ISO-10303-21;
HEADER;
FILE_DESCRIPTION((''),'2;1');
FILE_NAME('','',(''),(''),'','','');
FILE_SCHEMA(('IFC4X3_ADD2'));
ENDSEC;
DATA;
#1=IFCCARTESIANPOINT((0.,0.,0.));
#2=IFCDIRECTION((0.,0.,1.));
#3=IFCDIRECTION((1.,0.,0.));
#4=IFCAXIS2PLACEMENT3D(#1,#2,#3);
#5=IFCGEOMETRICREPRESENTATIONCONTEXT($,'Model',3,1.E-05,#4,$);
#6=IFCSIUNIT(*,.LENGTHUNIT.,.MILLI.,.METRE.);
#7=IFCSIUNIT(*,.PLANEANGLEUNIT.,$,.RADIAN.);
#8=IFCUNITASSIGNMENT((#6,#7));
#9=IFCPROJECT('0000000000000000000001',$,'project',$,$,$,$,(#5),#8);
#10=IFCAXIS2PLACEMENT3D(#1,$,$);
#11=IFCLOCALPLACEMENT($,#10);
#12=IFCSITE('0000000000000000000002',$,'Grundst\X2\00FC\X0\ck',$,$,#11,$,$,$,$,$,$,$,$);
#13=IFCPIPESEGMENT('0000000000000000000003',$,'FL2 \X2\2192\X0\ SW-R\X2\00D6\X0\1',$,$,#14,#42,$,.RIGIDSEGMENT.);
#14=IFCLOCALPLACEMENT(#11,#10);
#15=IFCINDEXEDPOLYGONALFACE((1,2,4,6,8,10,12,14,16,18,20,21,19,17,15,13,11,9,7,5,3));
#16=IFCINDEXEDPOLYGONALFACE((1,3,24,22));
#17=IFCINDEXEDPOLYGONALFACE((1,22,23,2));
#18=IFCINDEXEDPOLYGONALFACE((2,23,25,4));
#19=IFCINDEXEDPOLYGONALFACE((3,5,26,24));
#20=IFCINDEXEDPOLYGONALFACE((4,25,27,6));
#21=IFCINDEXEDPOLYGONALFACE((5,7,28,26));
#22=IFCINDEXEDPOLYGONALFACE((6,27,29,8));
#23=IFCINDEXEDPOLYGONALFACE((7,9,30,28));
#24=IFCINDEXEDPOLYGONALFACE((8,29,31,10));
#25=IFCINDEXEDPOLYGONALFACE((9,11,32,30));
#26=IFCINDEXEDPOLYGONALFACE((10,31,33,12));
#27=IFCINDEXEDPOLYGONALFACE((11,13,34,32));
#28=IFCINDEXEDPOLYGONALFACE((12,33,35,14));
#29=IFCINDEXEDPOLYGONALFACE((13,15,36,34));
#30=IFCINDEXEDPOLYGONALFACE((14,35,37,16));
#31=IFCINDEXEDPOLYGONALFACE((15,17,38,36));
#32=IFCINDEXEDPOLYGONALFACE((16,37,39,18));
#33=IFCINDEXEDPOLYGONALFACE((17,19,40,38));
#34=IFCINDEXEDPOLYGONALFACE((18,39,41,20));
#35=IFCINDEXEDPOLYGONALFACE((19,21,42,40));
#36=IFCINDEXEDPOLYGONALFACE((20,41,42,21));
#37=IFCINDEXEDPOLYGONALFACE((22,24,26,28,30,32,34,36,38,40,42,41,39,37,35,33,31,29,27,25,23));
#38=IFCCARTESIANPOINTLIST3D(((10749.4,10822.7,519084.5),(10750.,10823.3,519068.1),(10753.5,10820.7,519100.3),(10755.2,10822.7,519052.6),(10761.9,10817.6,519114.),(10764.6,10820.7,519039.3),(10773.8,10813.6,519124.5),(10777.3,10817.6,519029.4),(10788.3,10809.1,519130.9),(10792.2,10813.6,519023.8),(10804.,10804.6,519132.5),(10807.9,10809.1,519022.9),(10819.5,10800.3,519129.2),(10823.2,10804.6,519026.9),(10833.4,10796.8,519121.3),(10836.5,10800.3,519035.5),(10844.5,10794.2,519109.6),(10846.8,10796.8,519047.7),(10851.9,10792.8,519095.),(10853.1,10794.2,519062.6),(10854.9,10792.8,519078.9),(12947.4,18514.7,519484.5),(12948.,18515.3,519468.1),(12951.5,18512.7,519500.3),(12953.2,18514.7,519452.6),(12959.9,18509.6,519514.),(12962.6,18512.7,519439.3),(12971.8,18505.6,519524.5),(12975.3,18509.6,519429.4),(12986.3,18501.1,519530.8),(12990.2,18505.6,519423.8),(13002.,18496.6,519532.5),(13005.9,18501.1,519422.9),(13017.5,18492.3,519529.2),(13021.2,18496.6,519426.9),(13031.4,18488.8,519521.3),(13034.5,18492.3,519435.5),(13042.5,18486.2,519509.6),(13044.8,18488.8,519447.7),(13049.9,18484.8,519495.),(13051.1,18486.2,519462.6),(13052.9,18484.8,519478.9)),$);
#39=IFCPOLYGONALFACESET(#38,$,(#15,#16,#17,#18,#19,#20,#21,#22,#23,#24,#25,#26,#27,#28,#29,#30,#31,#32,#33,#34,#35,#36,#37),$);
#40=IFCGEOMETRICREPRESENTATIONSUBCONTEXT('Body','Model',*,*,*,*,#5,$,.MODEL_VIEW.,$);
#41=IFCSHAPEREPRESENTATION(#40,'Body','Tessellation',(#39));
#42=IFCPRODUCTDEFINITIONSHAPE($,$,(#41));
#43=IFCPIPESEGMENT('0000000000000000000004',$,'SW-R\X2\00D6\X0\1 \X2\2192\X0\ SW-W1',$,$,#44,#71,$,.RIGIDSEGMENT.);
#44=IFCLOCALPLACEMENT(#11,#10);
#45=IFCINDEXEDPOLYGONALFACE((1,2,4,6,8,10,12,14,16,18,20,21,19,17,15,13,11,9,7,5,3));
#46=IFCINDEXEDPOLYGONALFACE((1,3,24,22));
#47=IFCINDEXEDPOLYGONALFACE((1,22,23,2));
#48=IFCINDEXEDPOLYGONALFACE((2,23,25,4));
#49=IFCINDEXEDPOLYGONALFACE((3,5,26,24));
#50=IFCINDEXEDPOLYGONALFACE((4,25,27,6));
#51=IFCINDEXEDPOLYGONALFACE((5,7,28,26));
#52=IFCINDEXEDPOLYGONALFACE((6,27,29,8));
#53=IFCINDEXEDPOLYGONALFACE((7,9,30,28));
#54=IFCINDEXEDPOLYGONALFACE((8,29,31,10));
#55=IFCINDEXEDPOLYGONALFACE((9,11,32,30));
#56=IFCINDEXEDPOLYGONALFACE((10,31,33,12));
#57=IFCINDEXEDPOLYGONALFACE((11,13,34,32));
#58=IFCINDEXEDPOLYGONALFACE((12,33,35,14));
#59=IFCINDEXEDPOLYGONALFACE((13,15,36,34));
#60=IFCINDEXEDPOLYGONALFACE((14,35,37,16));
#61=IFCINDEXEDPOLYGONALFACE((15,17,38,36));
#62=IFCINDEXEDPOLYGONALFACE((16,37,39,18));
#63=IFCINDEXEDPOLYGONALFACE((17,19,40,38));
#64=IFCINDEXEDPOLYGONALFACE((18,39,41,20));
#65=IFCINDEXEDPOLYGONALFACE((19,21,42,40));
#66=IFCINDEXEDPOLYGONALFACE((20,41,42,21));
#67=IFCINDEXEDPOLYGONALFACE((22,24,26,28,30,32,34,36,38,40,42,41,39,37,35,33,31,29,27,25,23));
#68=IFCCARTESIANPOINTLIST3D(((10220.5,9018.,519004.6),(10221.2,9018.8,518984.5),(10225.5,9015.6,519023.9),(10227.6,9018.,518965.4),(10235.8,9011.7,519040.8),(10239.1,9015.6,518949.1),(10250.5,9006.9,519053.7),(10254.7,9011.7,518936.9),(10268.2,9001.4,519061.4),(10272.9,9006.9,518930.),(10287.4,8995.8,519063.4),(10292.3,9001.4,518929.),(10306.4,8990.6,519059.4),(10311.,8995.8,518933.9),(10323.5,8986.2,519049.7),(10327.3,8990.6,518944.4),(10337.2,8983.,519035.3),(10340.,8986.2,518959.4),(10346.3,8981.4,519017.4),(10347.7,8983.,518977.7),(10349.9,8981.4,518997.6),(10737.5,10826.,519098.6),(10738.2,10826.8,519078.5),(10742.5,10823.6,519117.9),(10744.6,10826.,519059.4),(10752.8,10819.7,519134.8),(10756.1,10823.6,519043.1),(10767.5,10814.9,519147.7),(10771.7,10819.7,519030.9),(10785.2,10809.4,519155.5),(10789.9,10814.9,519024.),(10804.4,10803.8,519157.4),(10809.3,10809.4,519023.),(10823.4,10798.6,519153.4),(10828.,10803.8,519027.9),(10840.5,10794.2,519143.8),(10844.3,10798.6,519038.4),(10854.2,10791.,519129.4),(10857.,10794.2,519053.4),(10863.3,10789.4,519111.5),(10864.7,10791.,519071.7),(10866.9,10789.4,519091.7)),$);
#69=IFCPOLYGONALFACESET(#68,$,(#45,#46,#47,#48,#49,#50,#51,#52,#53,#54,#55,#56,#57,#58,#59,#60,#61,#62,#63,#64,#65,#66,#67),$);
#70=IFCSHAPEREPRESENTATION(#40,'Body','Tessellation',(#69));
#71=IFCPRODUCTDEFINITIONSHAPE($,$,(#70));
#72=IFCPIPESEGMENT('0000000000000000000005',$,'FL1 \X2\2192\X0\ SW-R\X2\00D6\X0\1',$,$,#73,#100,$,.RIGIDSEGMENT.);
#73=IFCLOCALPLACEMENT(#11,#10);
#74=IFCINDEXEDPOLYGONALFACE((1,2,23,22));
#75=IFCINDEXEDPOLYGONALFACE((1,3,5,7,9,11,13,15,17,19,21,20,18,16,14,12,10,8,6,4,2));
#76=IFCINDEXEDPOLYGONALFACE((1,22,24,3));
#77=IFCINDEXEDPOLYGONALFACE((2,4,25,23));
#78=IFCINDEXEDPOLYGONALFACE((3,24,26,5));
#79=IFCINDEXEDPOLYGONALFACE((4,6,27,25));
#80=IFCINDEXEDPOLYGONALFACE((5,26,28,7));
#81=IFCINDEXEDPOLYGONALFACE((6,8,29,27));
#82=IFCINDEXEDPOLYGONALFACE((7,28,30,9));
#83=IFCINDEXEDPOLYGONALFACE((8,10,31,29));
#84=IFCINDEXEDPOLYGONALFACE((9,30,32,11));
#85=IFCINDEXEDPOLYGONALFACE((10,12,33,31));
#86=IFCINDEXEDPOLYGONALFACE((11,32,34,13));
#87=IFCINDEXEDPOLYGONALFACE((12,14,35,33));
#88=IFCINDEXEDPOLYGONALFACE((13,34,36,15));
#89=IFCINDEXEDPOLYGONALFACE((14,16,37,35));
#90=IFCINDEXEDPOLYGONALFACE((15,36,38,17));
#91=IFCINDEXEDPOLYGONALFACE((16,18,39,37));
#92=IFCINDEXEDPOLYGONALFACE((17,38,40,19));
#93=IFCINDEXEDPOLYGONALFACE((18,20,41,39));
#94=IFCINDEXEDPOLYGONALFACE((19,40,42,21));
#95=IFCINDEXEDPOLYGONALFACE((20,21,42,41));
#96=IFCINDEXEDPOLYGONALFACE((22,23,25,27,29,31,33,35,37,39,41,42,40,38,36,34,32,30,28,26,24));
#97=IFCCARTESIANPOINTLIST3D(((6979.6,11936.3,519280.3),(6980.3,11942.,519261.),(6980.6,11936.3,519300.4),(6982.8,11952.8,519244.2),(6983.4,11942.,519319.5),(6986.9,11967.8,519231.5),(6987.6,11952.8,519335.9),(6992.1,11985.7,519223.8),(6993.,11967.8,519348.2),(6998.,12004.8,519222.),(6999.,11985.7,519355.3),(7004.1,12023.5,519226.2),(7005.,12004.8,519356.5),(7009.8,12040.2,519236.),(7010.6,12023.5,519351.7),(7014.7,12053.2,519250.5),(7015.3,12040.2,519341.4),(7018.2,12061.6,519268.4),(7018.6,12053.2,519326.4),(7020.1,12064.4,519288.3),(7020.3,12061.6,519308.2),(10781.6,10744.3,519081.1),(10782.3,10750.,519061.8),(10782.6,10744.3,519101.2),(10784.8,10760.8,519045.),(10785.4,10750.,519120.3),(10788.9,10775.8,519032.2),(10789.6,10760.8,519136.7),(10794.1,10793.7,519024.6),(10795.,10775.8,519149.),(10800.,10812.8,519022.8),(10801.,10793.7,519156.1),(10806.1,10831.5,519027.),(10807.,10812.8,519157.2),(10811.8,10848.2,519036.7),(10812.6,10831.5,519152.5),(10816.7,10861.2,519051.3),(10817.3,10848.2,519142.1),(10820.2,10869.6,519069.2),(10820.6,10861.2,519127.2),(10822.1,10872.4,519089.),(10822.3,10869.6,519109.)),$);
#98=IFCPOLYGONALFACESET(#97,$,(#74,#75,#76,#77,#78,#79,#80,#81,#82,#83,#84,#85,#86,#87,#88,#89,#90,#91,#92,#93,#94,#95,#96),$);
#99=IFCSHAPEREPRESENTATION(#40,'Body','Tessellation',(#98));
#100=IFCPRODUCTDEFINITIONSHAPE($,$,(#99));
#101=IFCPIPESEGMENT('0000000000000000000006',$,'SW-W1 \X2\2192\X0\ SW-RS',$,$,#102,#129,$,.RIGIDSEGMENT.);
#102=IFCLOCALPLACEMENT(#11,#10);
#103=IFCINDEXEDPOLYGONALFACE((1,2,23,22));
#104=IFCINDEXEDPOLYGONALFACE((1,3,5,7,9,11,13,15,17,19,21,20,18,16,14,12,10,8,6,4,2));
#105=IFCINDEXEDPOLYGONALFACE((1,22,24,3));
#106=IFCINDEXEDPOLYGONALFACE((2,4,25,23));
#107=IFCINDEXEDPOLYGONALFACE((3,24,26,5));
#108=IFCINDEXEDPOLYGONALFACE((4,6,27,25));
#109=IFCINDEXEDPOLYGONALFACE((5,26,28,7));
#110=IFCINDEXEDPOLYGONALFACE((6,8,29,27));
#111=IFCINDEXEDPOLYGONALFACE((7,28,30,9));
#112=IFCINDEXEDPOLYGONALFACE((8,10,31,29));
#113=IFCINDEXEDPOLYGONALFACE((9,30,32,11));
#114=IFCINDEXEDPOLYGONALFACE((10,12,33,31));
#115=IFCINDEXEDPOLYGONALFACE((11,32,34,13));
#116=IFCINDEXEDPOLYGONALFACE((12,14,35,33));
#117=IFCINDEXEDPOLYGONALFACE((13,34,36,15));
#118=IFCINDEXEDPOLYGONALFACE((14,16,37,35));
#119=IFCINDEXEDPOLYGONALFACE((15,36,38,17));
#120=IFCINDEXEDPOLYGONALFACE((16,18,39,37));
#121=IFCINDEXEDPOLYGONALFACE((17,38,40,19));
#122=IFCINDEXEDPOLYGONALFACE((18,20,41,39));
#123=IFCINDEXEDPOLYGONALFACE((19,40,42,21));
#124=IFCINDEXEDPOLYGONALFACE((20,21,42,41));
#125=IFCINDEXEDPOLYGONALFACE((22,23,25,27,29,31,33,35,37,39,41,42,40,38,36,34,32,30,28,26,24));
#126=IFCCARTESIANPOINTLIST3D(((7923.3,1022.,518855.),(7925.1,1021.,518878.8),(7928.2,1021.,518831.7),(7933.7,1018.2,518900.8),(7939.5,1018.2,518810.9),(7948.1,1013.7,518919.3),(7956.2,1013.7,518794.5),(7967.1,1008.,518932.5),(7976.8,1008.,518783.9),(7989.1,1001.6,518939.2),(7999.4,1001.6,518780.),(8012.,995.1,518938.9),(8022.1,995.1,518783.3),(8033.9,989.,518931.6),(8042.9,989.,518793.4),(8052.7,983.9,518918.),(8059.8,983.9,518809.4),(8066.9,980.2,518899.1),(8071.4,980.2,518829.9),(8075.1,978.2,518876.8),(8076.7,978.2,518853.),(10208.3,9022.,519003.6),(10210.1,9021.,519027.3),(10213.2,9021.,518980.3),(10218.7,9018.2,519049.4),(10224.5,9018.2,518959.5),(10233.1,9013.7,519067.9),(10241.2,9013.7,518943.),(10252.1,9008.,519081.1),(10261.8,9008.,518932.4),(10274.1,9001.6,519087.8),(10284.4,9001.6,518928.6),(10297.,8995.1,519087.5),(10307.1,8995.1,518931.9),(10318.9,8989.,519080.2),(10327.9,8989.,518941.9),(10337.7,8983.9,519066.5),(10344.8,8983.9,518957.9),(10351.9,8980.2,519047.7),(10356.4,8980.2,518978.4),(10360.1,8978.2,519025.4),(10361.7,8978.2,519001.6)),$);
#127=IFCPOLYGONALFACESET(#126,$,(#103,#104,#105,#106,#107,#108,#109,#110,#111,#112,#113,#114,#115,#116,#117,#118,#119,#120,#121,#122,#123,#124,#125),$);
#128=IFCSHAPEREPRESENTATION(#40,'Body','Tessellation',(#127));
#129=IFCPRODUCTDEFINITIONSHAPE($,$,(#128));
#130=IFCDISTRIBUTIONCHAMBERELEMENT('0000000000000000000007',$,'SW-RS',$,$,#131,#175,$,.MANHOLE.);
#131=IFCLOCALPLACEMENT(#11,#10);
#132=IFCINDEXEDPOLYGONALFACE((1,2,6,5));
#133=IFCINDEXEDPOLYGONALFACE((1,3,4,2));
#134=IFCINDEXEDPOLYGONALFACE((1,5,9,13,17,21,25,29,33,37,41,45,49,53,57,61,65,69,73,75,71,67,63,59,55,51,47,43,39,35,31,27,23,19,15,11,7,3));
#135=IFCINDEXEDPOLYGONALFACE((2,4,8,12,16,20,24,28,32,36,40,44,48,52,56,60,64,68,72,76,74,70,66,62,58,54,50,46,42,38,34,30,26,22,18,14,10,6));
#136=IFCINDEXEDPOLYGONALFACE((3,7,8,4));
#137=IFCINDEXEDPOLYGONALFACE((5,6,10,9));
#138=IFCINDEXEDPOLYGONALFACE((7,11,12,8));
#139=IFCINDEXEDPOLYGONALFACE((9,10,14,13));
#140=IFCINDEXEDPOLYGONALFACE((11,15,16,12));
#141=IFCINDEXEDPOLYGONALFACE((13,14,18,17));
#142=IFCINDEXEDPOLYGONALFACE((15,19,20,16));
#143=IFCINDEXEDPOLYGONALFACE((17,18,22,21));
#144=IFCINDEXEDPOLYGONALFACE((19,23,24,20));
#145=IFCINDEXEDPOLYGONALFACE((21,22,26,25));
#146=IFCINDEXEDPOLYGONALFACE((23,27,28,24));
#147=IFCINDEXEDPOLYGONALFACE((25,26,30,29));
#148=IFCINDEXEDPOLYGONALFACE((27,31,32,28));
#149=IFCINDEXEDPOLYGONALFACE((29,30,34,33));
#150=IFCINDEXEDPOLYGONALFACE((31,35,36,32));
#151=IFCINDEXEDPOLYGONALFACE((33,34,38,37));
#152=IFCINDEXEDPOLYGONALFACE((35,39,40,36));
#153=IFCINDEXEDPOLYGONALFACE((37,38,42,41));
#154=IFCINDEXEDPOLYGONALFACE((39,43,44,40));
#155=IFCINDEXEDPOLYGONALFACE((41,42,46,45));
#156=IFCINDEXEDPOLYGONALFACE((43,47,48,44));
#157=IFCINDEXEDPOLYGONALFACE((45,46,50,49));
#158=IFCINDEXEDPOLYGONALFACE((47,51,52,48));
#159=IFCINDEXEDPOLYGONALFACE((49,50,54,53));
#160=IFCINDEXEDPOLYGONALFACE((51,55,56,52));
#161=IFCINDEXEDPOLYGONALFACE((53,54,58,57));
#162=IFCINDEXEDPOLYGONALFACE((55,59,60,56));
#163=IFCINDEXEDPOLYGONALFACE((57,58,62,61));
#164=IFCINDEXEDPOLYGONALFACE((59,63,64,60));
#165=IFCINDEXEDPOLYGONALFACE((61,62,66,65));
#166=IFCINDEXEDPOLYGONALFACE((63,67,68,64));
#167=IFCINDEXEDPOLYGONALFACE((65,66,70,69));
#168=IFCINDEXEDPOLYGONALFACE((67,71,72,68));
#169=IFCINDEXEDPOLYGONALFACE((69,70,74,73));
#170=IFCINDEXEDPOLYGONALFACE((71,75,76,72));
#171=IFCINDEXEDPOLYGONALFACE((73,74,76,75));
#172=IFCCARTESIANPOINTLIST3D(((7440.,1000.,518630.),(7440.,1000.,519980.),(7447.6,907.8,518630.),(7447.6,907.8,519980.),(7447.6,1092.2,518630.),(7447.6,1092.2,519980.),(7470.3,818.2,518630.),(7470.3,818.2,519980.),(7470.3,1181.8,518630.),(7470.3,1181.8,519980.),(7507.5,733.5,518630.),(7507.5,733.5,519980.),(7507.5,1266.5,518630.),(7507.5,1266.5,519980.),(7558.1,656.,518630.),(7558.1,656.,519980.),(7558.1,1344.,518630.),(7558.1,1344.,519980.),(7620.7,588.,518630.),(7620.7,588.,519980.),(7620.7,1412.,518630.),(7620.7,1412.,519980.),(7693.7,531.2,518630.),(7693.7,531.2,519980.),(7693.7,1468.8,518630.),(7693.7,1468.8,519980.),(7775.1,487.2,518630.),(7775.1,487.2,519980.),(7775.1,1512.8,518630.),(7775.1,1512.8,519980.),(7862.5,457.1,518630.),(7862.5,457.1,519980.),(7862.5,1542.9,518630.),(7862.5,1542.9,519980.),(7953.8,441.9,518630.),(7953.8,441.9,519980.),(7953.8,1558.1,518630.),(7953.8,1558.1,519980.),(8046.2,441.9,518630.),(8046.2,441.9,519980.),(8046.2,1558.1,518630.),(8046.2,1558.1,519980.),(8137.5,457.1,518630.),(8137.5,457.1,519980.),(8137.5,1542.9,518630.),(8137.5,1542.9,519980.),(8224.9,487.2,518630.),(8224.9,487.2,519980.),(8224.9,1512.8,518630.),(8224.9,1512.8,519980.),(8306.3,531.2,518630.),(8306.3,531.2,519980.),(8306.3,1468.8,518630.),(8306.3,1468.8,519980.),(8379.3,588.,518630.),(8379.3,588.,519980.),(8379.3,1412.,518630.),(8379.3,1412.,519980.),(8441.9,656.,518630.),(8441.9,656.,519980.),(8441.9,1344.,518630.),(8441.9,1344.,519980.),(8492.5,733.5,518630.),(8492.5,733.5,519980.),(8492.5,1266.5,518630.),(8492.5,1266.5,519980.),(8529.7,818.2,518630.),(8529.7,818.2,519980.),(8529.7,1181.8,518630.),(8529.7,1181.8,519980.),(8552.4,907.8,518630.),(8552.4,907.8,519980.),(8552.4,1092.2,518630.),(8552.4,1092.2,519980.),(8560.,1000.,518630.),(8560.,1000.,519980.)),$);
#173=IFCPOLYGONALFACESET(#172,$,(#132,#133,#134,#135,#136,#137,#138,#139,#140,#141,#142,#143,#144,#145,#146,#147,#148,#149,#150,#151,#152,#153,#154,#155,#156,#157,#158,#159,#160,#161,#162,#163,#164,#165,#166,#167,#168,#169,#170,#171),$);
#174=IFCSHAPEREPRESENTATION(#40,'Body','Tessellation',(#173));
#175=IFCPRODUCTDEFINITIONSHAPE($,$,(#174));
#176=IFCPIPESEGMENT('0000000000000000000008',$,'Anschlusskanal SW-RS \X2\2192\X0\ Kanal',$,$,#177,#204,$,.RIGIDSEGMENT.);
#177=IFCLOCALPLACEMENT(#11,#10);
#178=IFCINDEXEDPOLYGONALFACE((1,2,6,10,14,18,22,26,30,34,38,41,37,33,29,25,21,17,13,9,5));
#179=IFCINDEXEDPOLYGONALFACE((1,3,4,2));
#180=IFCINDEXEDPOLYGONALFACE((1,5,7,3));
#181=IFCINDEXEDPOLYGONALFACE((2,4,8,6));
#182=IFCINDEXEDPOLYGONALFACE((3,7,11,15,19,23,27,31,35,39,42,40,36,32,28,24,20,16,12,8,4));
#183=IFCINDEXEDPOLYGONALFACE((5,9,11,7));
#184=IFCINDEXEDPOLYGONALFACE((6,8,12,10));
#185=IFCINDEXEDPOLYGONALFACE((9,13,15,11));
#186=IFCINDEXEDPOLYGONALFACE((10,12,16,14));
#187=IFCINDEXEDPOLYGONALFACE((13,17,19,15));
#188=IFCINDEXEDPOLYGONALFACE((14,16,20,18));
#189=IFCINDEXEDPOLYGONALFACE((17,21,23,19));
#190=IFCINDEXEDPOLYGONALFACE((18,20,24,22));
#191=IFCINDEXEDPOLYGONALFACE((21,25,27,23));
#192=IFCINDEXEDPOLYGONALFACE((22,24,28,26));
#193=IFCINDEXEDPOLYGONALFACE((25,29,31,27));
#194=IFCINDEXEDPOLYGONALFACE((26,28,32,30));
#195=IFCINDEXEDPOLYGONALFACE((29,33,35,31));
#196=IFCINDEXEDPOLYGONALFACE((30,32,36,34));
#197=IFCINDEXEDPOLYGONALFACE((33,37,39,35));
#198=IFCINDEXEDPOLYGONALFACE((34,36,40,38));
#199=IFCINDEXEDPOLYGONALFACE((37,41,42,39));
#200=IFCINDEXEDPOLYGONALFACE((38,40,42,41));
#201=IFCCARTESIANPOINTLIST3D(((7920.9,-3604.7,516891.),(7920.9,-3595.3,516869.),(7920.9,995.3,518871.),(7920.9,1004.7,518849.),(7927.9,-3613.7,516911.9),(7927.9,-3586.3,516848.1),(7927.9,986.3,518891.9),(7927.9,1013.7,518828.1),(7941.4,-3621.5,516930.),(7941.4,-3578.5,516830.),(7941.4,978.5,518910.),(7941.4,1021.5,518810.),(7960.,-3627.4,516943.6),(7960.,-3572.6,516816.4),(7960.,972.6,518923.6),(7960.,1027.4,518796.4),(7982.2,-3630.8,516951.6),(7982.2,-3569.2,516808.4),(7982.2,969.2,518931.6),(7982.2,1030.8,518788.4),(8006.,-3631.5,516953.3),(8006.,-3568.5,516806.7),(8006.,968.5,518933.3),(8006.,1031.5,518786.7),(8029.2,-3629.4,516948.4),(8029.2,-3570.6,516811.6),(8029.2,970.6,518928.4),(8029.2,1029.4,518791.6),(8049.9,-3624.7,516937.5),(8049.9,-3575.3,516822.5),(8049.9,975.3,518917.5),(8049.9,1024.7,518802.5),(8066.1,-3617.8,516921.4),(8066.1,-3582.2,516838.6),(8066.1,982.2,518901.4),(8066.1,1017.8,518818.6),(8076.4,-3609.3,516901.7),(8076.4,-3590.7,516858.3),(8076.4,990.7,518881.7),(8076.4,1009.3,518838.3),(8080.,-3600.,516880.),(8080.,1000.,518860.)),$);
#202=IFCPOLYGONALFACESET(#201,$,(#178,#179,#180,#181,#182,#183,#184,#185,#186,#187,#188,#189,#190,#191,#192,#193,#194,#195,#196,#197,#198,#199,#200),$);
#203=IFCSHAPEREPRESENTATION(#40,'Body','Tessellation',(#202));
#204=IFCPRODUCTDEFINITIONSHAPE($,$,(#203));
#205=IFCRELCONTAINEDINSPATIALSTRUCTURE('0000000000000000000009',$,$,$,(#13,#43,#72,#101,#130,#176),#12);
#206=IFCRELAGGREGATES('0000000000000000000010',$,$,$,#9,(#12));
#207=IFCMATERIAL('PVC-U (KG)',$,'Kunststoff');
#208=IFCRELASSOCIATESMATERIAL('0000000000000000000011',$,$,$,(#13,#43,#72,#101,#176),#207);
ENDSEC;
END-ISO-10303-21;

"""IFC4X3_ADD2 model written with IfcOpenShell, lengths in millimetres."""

from ifc_helpers import new_model, si_unit, frame, origin, origin_with_axes, place, context, subcontext, project, spatial, circle, extrude, material, element, save


model = new_model("IFC4X3_ADD2")

# Units and contexts
model_context = context("Model", 3, precision=1e-05, world=origin_with_axes())
body_context = subcontext(model_context, "Body", "Model", "MODEL_VIEW")
ifc_project = project(units=[si_unit("LENGTHUNIT", "METRE", prefix="MILLI"), si_unit("PLANEANGLEUNIT", "RADIAN")], contexts=[model_context])

# Site
site_placement = place(None, origin())
site = spatial("IfcSite", under=ifc_project, at=site_placement, Name="Grundstück")

# Pipe segments
ifc_material = material(Name="PVC-U (KG)", Category="Kunststoff")
pipe_segment_1_placement = place(site_placement, frame((13000.0, 18500.0, 519422.6)))
element("IfcPipeSegment", 1, at=pipe_segment_1_placement, inside=site, material=ifc_material, Name="FL2 → SW-RÖ1", PredefinedType="RIGIDSEGMENT", context=body_context, shape_type="SweptSolid", body=[
    extrude(circle(Radius=55.0), frame((0.0, 0.0, 55.0), z_axis=(-0.274411, -0.960315, -0.049938), x_axis=(0.0, 1.0, 0.0)), (0.0, 0.0, 1.0), 8009.9),
])
pipe_segment_2_placement = place(site_placement, frame((10802.0, 10808.0, 519022.6)))
element("IfcPipeSegment", 2, at=pipe_segment_2_placement, inside=site, material=ifc_material, Name="SW-RÖ1 → SW-W1", PredefinedType="RIGIDSEGMENT", context=body_context, shape_type="SweptSolid", body=[
    extrude(circle(Radius=67.5), frame((0.0, 0.0, 67.5), z_axis=(-0.274589, -0.960264, -0.049938), x_axis=(0.0, 1.0, 0.0)), (0.0, 0.0, 1.0), 1882.8),
])
pipe_segment_3_placement = place(site_placement, frame((7000.0, 12000.0, 519221.8)))
element("IfcPipeSegment", 3, at=pipe_segment_3_placement, inside=site, material=ifc_material, Name="FL1 → SW-RÖ1", PredefinedType="RIGIDSEGMENT", context=body_context, shape_type="SweptSolid", body=[
    extrude(circle(Radius=67.5), frame((0.0, 0.0, 67.5), z_axis=(0.953012, -0.298788, -0.049938), x_axis=(0.0, 1.0, 0.0)), (0.0, 0.0, 1.0), 3989.5),
])
pipe_segment_4_placement = place(site_placement, frame((10285.0, 9000.0, 518928.6)))
element("IfcPipeSegment", 4, at=pipe_segment_4_placement, inside=site, material=ifc_material, Name="SW-W1 → SW-RS", PredefinedType="RIGIDSEGMENT", context=body_context, shape_type="SweptSolid", body=[
    extrude(circle(Radius=80.0), frame((0.0, 0.0, 80.0), z_axis=(-0.274598, -0.961393, -0.017855), x_axis=(0.0, 1.0, 0.0)), (0.0, 0.0, 1.0), 8321.3),
])

# Distribution chamber element
distribution_chamber_element_1_placement = place(site_placement, frame((8000.0, 1000.0, 518780.0)))
element("IfcDistributionChamberElement", 5, at=distribution_chamber_element_1_placement, inside=site, Name="SW-RS", PredefinedType="MANHOLE", context=body_context, shape_type="SweptSolid", body=[
    extrude(circle(Radius=560.0), frame((0.0, 0.0, -150.0)), (0.0, 0.0, 1.0), 1350.0),
])

# Pipe segment
pipe_segment_5_placement = place(site_placement, frame((8000.0, 1000.0, 518780.0)))
element("IfcPipeSegment", 6, at=pipe_segment_5_placement, inside=site, material=ifc_material, Name="Anschlusskanal SW-RS → Kanal", PredefinedType="RIGIDSEGMENT", context=body_context, shape_type="SweptSolid", body=[
    extrude(circle(Radius=80.0), frame((0.0, 0.0, 80.0), z_axis=(0.0, -0.918524, -0.395365), x_axis=(1.0, 0.0, 0.0)), (0.0, 0.0, 1.0), 5008.0),
])

save(model, "model.ifc")
